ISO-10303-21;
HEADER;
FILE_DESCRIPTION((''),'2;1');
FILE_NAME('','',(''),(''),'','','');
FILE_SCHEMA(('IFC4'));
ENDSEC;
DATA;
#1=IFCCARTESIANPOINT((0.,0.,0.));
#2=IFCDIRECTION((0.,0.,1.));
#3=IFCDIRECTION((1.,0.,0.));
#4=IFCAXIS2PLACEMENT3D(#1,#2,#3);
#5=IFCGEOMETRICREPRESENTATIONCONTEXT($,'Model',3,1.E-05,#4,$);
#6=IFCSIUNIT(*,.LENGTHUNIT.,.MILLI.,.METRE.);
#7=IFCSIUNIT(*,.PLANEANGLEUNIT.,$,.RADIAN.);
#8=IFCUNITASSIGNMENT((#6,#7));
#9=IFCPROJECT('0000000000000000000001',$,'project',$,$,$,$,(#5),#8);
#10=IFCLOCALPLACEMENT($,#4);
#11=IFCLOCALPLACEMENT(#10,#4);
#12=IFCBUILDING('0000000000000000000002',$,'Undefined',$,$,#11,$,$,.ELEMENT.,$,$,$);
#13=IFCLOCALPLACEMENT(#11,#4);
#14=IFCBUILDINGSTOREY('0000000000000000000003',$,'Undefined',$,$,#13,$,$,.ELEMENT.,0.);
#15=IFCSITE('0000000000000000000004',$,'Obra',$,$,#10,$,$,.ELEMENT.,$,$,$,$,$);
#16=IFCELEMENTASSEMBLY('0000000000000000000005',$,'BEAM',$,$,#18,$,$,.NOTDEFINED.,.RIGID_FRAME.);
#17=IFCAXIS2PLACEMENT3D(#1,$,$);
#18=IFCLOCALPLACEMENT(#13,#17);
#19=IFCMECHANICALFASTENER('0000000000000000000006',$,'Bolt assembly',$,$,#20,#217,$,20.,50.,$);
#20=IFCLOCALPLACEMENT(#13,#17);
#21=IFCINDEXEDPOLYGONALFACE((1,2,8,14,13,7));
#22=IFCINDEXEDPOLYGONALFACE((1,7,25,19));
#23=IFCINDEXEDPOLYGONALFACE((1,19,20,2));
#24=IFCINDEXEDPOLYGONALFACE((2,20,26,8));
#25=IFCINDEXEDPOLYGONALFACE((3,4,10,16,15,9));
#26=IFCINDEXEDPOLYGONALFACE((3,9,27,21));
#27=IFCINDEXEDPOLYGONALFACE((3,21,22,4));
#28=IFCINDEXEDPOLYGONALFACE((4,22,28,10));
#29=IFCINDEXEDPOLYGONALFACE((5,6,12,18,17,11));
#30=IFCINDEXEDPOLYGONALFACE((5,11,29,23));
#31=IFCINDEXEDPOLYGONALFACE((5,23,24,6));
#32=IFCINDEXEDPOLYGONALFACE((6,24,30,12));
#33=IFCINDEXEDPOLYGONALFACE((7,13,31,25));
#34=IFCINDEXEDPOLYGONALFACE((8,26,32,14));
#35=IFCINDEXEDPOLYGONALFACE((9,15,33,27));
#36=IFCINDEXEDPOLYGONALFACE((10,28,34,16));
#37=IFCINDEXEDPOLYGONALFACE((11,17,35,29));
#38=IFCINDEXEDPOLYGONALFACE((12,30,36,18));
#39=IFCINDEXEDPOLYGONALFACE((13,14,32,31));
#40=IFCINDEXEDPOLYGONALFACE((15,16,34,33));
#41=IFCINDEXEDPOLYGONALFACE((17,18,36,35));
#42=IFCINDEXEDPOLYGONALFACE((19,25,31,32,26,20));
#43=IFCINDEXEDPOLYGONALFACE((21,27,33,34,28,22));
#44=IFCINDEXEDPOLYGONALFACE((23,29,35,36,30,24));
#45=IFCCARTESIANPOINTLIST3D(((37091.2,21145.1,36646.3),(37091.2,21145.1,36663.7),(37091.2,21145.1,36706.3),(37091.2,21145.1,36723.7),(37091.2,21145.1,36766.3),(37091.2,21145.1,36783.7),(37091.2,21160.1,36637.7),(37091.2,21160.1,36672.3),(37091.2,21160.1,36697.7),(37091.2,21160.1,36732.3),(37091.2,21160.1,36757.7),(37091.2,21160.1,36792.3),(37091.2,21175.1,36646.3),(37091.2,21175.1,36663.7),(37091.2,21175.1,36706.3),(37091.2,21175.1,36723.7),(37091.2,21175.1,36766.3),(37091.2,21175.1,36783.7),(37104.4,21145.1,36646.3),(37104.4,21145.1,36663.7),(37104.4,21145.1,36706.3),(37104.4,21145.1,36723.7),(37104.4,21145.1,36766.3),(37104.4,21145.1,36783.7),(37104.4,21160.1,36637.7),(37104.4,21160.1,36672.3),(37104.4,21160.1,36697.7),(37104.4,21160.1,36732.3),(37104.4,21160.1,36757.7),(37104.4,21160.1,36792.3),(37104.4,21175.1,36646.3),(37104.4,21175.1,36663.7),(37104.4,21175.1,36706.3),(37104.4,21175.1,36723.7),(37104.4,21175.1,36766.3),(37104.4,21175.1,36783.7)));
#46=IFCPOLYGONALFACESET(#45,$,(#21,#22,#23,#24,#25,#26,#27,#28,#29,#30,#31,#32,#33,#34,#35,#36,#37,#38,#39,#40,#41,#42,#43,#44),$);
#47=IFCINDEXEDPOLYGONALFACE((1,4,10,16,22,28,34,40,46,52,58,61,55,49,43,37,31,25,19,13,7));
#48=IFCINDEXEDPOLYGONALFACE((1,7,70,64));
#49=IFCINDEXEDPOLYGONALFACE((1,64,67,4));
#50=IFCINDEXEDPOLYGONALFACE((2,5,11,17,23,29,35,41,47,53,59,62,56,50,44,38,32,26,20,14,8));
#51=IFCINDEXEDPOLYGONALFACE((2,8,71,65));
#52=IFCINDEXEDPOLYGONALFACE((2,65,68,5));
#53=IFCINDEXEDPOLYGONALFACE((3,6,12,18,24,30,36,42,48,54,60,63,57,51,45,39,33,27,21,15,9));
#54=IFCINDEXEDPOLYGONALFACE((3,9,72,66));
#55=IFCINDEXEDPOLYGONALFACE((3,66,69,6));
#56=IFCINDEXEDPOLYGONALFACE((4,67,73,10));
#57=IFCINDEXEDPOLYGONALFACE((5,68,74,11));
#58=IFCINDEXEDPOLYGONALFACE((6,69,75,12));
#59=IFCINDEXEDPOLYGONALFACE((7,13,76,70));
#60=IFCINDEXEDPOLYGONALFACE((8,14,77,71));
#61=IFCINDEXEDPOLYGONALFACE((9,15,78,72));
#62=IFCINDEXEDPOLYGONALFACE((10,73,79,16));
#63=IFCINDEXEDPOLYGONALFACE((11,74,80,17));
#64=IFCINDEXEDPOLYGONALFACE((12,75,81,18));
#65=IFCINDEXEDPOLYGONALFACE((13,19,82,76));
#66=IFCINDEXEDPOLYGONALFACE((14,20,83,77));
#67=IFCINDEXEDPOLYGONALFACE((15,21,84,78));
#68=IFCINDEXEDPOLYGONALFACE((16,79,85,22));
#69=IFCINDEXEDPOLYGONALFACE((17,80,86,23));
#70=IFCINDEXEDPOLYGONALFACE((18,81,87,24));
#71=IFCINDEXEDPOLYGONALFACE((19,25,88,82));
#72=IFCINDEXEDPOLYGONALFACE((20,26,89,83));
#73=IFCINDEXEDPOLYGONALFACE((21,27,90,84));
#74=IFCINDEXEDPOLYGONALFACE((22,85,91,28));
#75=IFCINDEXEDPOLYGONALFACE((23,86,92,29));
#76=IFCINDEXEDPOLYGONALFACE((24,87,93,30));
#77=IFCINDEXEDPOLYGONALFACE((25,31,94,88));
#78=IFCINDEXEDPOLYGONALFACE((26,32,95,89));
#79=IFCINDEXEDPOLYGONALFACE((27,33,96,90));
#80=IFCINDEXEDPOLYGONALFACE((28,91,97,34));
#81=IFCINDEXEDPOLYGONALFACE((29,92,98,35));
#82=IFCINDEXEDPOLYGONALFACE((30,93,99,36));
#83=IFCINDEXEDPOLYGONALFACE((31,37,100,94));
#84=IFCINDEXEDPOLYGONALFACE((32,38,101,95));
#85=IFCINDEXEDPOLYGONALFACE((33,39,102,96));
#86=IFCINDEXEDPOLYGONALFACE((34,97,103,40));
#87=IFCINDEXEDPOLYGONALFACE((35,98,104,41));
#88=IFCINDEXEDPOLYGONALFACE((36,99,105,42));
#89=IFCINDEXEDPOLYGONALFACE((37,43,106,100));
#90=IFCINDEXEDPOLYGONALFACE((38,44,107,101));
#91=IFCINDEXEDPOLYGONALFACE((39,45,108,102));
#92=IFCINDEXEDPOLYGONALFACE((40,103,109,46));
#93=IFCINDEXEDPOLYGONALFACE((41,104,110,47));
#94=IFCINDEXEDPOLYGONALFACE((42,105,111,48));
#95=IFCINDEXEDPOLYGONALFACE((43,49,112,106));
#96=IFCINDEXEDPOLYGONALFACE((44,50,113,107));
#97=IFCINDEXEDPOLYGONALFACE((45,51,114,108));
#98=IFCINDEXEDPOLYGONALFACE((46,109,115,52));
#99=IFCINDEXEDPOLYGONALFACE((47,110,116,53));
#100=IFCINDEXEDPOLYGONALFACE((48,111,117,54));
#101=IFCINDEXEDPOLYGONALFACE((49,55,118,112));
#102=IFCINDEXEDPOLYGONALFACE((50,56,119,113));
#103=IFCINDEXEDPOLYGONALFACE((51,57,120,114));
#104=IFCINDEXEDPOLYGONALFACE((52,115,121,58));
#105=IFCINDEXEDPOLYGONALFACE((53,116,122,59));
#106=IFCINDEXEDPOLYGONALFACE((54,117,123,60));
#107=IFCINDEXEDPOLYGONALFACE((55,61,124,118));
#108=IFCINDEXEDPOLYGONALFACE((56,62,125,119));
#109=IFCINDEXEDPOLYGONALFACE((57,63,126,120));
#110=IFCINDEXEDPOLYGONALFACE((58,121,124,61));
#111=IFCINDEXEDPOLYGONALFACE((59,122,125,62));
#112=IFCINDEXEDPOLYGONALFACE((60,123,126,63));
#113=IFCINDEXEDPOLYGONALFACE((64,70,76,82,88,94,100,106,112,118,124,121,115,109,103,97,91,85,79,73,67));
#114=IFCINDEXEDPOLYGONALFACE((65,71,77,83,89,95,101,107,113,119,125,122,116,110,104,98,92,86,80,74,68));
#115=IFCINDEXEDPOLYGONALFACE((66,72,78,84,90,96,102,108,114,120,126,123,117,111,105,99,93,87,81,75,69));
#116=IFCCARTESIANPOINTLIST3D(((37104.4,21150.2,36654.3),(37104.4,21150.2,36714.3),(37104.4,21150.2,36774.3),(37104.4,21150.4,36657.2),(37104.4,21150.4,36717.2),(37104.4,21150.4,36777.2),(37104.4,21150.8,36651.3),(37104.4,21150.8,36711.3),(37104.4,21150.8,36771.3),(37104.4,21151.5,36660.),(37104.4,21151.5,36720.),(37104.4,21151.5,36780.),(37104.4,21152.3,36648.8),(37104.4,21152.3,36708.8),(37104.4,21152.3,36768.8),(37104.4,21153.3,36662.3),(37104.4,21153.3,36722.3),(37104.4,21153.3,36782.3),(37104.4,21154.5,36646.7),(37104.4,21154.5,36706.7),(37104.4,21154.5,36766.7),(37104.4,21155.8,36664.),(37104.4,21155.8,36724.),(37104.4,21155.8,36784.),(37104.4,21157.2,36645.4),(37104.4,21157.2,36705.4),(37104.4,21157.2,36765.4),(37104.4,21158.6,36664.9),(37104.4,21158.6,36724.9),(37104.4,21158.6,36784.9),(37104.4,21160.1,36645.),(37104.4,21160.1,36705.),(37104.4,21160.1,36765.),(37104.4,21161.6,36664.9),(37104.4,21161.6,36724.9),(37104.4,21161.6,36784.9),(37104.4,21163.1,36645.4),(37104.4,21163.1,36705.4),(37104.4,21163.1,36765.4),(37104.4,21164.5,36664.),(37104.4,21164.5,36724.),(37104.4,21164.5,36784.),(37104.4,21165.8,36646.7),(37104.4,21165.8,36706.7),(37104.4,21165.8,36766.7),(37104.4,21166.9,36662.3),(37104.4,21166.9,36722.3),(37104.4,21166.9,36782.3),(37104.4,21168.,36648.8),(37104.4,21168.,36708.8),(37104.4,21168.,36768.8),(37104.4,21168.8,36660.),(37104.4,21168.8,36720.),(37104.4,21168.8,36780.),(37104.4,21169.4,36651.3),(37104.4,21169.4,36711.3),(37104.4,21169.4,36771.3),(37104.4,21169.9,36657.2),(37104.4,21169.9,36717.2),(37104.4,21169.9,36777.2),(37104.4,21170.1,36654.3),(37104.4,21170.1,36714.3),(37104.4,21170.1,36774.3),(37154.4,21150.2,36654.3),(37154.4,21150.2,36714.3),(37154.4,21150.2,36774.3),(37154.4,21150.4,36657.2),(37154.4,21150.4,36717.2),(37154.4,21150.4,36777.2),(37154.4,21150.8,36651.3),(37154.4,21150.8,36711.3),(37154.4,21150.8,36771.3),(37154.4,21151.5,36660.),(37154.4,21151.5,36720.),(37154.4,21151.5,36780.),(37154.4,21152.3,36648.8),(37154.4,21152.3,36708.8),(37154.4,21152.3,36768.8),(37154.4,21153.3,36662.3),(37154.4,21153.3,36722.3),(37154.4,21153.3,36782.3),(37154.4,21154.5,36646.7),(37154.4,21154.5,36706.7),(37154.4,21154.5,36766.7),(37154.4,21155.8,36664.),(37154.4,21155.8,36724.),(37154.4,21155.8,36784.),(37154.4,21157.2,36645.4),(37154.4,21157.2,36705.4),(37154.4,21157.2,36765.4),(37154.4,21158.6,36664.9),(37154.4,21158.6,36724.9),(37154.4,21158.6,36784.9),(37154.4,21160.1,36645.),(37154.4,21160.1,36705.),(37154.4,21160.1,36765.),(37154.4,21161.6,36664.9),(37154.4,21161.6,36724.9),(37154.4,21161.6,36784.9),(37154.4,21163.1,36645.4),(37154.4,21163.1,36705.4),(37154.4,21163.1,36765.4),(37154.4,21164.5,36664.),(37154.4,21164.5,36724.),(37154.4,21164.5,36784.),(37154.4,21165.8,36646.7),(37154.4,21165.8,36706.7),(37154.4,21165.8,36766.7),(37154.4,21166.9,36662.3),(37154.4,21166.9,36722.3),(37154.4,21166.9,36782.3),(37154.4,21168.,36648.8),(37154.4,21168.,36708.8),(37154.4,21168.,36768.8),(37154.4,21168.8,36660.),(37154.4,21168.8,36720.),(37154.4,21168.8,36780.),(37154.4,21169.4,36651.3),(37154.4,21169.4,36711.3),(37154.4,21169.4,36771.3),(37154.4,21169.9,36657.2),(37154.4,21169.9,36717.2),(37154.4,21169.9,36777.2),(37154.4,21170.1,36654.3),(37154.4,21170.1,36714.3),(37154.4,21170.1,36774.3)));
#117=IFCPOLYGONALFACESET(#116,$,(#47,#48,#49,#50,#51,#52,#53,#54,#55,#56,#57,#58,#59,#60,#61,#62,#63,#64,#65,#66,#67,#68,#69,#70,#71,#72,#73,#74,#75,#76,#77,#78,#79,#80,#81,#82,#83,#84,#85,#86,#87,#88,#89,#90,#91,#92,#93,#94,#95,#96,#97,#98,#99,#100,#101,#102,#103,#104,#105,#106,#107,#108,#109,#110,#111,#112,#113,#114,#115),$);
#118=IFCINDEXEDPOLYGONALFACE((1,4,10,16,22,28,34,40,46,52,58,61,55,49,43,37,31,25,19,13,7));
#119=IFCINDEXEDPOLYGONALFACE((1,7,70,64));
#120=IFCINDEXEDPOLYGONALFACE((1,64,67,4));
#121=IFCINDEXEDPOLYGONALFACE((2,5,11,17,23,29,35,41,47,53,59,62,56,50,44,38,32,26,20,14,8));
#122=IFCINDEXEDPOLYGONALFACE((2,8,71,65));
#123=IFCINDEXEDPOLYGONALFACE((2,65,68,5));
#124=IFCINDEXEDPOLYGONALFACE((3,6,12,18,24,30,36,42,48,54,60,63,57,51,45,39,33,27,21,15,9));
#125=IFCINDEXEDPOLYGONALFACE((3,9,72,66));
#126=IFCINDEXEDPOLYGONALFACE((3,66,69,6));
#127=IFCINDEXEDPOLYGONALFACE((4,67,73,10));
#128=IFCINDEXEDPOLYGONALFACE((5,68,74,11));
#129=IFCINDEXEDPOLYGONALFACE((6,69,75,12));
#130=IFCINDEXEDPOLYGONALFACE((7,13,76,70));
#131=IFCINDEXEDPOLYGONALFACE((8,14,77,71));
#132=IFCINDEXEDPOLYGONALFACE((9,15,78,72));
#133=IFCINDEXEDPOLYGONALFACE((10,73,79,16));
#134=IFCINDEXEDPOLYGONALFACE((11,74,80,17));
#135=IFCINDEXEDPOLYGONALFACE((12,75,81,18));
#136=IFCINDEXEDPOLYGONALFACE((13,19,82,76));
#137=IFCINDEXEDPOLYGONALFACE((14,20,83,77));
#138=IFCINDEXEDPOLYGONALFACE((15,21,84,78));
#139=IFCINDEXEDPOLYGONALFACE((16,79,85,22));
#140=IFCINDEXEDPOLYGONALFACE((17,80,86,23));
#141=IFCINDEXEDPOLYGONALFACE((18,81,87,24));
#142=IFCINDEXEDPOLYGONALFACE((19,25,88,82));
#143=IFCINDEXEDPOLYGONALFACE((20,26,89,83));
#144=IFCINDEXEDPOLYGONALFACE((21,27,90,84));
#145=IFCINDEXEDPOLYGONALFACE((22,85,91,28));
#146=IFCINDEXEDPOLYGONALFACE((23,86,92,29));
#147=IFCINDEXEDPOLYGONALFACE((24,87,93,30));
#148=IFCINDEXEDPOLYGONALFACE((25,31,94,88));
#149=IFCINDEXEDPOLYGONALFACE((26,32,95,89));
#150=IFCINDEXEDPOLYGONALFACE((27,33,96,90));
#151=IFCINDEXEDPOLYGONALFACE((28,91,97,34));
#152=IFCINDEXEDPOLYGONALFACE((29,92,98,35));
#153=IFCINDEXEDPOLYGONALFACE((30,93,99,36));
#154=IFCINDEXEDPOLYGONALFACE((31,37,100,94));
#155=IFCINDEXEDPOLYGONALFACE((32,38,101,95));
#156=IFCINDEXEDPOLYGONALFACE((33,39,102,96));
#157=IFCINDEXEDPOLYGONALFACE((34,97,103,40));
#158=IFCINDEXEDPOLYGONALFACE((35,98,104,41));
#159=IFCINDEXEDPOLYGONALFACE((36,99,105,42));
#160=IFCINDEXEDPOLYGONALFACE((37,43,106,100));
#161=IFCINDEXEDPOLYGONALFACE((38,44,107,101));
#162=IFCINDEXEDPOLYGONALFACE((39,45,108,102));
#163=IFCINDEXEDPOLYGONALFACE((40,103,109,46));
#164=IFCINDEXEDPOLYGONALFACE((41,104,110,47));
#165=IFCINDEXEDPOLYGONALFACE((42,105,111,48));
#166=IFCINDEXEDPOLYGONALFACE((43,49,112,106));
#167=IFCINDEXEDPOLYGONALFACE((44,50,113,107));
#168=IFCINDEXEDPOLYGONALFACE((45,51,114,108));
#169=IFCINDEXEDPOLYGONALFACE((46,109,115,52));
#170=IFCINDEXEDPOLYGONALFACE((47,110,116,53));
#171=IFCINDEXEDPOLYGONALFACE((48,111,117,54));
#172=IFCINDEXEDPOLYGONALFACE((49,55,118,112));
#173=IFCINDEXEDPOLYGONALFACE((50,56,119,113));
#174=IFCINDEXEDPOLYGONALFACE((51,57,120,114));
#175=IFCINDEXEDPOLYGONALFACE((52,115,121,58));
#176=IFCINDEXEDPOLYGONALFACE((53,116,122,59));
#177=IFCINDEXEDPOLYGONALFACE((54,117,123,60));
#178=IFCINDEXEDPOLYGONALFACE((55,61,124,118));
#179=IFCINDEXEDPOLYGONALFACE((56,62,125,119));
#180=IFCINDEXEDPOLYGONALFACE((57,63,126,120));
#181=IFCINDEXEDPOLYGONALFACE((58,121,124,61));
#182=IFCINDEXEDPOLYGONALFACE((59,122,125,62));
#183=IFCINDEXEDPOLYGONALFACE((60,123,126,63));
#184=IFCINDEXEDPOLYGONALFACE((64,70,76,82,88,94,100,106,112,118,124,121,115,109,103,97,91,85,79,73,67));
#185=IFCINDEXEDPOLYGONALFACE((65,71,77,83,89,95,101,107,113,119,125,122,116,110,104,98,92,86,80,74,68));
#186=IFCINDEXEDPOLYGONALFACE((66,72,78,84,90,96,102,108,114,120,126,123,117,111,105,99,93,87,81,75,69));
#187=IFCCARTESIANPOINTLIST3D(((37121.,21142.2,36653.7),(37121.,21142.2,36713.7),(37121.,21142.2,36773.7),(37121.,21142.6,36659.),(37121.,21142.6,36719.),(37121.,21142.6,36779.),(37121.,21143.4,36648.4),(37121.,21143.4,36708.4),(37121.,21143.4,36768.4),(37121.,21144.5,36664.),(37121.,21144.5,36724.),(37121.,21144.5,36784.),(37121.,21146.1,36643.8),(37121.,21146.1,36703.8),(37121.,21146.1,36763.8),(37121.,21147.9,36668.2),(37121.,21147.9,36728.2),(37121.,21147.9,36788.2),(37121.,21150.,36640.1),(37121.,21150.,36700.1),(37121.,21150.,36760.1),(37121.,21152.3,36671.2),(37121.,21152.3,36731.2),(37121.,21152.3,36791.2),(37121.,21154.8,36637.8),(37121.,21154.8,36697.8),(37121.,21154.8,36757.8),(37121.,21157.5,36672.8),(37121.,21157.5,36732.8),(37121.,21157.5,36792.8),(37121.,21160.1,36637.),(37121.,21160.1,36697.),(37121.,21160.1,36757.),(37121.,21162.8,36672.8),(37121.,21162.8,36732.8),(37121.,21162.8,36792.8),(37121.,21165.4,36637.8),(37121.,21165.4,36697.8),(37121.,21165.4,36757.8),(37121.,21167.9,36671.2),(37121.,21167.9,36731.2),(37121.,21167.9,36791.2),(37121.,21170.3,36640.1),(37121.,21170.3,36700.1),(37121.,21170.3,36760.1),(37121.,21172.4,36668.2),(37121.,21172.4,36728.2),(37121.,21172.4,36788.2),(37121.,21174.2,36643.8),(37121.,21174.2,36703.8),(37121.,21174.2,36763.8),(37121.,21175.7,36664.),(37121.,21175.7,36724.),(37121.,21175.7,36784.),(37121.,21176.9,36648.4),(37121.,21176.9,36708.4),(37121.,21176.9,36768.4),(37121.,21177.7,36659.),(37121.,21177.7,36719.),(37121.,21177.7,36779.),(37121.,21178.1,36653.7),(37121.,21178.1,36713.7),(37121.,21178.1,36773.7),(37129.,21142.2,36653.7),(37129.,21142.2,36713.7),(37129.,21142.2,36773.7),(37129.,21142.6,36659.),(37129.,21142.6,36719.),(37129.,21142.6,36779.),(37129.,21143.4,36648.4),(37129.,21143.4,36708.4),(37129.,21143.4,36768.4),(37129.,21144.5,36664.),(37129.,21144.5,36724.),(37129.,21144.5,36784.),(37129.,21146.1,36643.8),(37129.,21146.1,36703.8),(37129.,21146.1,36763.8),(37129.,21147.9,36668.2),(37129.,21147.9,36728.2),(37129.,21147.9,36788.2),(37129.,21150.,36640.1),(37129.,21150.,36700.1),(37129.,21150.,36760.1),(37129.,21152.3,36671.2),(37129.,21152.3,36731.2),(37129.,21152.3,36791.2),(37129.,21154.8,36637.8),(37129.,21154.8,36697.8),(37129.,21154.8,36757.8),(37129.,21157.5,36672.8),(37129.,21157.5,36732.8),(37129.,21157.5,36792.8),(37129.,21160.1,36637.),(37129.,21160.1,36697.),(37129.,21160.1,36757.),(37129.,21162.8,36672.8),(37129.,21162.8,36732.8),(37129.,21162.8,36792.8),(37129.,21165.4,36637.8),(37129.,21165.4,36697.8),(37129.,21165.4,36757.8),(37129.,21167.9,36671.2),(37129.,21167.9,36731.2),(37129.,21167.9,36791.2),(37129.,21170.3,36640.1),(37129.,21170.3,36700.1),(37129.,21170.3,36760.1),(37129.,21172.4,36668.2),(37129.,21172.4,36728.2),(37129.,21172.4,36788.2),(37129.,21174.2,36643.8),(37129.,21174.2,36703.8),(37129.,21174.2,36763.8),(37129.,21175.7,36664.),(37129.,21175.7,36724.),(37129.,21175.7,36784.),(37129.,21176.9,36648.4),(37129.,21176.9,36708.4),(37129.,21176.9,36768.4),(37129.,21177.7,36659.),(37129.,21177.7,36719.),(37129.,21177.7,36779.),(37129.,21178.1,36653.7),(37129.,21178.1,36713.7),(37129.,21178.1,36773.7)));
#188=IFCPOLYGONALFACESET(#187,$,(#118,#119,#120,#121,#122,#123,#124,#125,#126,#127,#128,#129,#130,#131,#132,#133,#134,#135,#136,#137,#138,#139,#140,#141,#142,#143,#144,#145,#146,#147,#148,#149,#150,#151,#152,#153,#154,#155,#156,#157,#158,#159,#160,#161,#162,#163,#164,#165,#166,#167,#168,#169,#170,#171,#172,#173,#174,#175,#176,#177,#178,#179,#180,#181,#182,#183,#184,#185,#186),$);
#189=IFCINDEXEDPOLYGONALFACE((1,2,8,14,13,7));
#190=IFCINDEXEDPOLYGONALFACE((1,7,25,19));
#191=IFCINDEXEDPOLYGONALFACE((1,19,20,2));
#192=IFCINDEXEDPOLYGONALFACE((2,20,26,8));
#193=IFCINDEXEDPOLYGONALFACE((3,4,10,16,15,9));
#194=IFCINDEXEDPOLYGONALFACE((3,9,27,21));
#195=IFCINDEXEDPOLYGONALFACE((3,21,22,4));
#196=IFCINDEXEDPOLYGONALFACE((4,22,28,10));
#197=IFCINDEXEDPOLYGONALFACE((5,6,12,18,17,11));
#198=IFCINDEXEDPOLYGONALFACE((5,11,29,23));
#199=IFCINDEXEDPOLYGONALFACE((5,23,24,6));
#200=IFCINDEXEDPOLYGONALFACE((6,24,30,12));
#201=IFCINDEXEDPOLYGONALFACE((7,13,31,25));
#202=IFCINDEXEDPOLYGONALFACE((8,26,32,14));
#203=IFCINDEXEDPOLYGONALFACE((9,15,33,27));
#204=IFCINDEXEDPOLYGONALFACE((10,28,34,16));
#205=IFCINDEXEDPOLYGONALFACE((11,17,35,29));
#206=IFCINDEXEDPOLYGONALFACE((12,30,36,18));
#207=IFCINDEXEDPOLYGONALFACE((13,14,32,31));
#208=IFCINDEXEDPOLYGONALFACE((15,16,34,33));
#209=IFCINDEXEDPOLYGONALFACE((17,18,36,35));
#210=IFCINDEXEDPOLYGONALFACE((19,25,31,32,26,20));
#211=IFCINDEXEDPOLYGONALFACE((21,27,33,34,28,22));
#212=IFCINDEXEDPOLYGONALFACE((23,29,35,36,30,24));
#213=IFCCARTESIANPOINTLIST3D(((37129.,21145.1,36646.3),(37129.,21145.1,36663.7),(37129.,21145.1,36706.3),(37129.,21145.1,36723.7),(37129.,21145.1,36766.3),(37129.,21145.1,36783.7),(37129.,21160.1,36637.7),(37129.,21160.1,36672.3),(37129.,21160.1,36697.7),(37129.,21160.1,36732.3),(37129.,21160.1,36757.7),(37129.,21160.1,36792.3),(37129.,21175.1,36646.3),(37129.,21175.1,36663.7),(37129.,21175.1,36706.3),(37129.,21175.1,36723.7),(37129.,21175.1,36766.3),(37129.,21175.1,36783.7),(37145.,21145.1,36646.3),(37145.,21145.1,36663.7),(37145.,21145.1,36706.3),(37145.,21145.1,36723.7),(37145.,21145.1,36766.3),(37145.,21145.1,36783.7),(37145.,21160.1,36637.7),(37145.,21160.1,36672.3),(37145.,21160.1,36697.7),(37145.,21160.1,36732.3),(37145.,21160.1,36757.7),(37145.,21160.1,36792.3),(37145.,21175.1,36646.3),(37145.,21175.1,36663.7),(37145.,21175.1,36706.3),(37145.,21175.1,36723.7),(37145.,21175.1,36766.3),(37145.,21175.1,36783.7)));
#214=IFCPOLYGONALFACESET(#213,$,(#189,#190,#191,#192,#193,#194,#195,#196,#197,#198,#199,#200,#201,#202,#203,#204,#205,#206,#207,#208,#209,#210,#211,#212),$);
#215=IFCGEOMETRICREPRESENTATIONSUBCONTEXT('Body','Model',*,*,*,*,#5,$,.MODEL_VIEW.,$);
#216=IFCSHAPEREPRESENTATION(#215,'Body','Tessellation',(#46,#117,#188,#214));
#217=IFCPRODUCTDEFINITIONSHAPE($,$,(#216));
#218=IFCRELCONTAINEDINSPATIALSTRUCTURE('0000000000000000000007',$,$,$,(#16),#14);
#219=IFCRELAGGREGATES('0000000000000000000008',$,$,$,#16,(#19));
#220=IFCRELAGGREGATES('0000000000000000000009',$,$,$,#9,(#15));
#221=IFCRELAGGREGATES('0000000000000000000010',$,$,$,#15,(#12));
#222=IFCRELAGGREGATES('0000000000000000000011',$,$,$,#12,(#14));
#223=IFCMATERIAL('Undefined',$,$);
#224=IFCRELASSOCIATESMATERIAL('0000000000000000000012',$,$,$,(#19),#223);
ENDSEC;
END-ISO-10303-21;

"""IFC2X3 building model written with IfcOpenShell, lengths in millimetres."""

from ifc_helpers import new_model, si_unit, frame, origin_with_axes, origin_2d_with_axis, place, context, subcontext, project, spatial, polyline, circle, outline, extrude, source, transform, mapped, material, element, aggregate, save


model = new_model("IFC2X3")

# Units and contexts
model_context = context("Model", 3, precision=1e-05, world=origin_with_axes())
body_context = subcontext(model_context, "Body", "Model", "MODEL_VIEW")
ifc_project = project(units=[si_unit("LENGTHUNIT", "METRE", prefix="MILLI"), si_unit("PLANEANGLEUNIT", "RADIAN")], contexts=[model_context])

# Site, building, storey
site_placement = place(None, origin_with_axes())
site = spatial("IfcSite", under=ifc_project, at=site_placement, Name="Obra", CompositionType="ELEMENT")
building_placement = place(site_placement, origin_with_axes())
building = spatial("IfcBuilding", under=site, at=building_placement, Name="Undefined", CompositionType="ELEMENT")
storey_placement = place(building_placement, origin_with_axes())
storey = spatial("IfcBuildingStorey", under=building, at=storey_placement, Name="Undefined", CompositionType="ELEMENT", Elevation=0.0)

# Element assembly
assembly_1_placement = place(storey_placement, origin_with_axes())
assembly_1 = element("IfcElementAssembly", 1, at=assembly_1_placement, inside=storey, Name="BEAM", AssemblyPlace="NOTDEFINED", PredefinedType="RIGID_FRAME")

# Mechanical fastener
ifc_material_1 = material(Name="Undefined")
shared_shape_1 = source(origin_with_axes(), body_context, "Body", "SweptSolid", [
    extrude(outline(polyline([(17.3, 0.0), (8.7, 15.0), (-8.7, 15.0), (-17.3, 0.0), (-8.7, -15.0), (8.7, -15.0), (17.3, 0.0)])), frame((0.0, -26.5, 0.0), z_axis=(0.0, 1.0, 0.0), x_axis=(1.0, 0.0, 0.0)), (0.0, 0.0, 1.0), 13.2),
    extrude(circle(Radius=10.0, at=origin_2d_with_axis()), frame((0.0, -13.3, 0.0), z_axis=(0.0, 1.0, 0.0), x_axis=(1.0, 0.0, 0.0)), (0.0, 0.0, 1.0), 50.0),
    extrude(circle(Radius=18.0, at=origin_2d_with_axis()), frame((0.0, 3.3, 0.0), z_axis=(0.0, 1.0, 0.0), x_axis=(1.0, 0.0, 0.0)), (0.0, 0.0, 1.0), 8.0),
    extrude(outline(polyline([(17.3, 0.0), (8.7, 15.0), (-8.7, 15.0), (-17.3, 0.0), (-8.7, -15.0), (8.7, -15.0), (17.3, 0.0)])), frame((0.0, 11.3, 0.0), z_axis=(0.0, 1.0, 0.0), x_axis=(1.0, 0.0, 0.0)), (0.0, 0.0, 1.0), 16.0),
])
mechanical_fastener_1_placement = place(assembly_1_placement, frame((37117.7, 21210.1, 36815.0), z_axis=(0.0, -1.0, 0.0), x_axis=(0.0, 0.0, -1.0)))
mechanical_fastener_1 = element("IfcMechanicalFastener", 2, at=mechanical_fastener_1_placement, material=ifc_material_1, Name="Bolt assembly", NominalDiameter=20.0, NominalLength=50.0, context=body_context, shape_type="MappedRepresentation", body=[
    mapped(shared_shape_1, transform((40.0, 0.0, 50.0))),
    mapped(shared_shape_1, transform((100.0, 0.0, 50.0))),
    mapped(shared_shape_1, transform((160.0, 0.0, 50.0))),
])
aggregate(assembly_1, [mechanical_fastener_1])

save(model, "model.ifc")
